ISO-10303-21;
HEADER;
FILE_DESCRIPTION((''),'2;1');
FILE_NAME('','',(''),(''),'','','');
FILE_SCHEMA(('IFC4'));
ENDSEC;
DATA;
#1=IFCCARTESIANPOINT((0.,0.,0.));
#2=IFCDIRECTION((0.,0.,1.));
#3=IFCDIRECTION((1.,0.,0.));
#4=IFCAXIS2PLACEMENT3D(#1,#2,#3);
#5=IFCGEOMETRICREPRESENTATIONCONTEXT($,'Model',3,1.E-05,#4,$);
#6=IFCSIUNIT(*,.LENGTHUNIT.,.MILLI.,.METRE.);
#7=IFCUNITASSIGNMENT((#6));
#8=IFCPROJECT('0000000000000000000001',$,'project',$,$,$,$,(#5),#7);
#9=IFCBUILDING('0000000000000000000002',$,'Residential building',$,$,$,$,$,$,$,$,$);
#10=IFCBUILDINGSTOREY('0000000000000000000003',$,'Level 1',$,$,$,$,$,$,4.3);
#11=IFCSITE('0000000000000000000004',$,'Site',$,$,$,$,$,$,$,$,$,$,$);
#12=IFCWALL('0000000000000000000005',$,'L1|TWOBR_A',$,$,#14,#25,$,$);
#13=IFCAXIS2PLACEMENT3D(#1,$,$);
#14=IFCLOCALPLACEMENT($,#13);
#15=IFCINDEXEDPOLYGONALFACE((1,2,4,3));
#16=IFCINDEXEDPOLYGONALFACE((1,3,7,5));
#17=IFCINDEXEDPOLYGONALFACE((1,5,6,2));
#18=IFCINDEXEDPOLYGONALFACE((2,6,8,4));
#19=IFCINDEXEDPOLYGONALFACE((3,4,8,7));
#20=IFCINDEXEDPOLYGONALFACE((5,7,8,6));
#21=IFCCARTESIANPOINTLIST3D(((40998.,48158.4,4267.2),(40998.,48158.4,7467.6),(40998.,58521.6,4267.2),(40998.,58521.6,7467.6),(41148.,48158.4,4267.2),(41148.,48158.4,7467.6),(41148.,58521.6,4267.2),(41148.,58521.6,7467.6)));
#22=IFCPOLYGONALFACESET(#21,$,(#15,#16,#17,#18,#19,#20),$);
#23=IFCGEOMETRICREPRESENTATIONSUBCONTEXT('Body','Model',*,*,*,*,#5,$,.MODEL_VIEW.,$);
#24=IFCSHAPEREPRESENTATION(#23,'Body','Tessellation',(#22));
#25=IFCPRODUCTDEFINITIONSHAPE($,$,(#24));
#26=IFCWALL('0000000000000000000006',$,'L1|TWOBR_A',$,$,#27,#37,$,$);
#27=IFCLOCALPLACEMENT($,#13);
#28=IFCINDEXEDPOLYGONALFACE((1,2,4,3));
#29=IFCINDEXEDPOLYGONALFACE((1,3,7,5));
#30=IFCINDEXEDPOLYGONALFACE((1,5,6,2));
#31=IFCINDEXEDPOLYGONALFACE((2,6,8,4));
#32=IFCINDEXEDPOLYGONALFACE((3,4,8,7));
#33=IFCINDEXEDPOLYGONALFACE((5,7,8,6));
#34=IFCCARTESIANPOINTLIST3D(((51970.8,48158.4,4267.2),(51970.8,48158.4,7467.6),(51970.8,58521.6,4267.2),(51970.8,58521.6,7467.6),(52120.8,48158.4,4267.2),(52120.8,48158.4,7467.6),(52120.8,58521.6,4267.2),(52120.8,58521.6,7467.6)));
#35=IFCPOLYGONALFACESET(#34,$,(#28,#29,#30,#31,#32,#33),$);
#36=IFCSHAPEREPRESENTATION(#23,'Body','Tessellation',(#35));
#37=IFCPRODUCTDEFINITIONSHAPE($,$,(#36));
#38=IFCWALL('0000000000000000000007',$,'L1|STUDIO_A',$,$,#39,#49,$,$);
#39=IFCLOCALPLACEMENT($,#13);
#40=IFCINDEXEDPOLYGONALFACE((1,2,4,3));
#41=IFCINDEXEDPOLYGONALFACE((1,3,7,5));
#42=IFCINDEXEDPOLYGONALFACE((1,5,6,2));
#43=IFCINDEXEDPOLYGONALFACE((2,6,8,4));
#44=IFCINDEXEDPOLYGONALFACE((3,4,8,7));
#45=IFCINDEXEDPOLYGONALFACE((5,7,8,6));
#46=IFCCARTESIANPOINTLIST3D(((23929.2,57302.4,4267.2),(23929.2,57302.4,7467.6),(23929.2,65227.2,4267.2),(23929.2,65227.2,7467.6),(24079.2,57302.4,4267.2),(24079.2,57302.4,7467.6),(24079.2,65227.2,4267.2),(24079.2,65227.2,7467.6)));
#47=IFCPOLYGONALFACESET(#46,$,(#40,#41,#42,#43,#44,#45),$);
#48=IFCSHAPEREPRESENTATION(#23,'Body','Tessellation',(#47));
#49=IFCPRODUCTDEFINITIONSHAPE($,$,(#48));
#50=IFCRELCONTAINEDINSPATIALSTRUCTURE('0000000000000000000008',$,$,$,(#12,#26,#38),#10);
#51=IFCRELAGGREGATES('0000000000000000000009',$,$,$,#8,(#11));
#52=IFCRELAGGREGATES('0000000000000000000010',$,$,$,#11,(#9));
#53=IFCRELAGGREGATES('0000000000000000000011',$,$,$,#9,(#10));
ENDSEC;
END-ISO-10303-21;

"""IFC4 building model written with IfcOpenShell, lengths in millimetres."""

from ifc_helpers import new_model, si_unit, frame, origin_with_axes, place, context, subcontext, project, spatial, indexed_curve, outline, extrude, element, save


model = new_model("IFC4")

# Units and contexts
model_context = context("Model", 3, precision=1e-05, world=origin_with_axes())
body_context = subcontext(model_context, "Body", "Model", "MODEL_VIEW")
ifc_project = project(units=[si_unit("LENGTHUNIT", "METRE", prefix="MILLI")], contexts=[model_context])

# Site, building, storey
site = spatial("IfcSite", under=ifc_project, Name="Site")
building = spatial("IfcBuilding", under=site, Name="Residential building")
storey = spatial("IfcBuildingStorey", under=building, Name="Level 1", Elevation=4.3)

# Walls
for number, where, z_axis, x_axis, name in (
    (1, (41148.0, 48158.4, 4267.2), (0.0, 0.0, 1.0), (0.0, 1.0, 0.0), "L1|TWOBR_A"),
    (2, (52120.8, 48158.4, 4267.2), (0.0, 0.0, 1.0), (0.0, 1.0, 0.0), "L1|TWOBR_A"),
):
    element("IfcWall", number, at=place(None, frame(where, z_axis=z_axis, x_axis=x_axis)), inside=storey, Name=name, context=body_context, shape_type="SweptSolid", body=[
        extrude(outline(indexed_curve([(0.0, 0.0), (0.0, 150.0), (10363.2, 150.0), (10363.2, 0.0), (0.0, 0.0)], self_intersect=False)), origin_with_axes(), (0.0, 0.0, 1.0), 3200.4),
    ])
wall_1_placement = place(None, frame((24079.2, 57302.4, 4267.2), z_axis=(0.0, 0.0, 1.0), x_axis=(0.0, 1.0, 0.0)))
element("IfcWall", 3, at=wall_1_placement, inside=storey, Name="L1|STUDIO_A", context=body_context, shape_type="SweptSolid", body=[
    extrude(outline(indexed_curve([(0.0, 0.0), (0.0, 150.0), (7924.8, 150.0), (7924.8, 0.0), (0.0, 0.0)], self_intersect=False)), origin_with_axes(), (0.0, 0.0, 1.0), 3200.4),
])

save(model, "model.ifc")
